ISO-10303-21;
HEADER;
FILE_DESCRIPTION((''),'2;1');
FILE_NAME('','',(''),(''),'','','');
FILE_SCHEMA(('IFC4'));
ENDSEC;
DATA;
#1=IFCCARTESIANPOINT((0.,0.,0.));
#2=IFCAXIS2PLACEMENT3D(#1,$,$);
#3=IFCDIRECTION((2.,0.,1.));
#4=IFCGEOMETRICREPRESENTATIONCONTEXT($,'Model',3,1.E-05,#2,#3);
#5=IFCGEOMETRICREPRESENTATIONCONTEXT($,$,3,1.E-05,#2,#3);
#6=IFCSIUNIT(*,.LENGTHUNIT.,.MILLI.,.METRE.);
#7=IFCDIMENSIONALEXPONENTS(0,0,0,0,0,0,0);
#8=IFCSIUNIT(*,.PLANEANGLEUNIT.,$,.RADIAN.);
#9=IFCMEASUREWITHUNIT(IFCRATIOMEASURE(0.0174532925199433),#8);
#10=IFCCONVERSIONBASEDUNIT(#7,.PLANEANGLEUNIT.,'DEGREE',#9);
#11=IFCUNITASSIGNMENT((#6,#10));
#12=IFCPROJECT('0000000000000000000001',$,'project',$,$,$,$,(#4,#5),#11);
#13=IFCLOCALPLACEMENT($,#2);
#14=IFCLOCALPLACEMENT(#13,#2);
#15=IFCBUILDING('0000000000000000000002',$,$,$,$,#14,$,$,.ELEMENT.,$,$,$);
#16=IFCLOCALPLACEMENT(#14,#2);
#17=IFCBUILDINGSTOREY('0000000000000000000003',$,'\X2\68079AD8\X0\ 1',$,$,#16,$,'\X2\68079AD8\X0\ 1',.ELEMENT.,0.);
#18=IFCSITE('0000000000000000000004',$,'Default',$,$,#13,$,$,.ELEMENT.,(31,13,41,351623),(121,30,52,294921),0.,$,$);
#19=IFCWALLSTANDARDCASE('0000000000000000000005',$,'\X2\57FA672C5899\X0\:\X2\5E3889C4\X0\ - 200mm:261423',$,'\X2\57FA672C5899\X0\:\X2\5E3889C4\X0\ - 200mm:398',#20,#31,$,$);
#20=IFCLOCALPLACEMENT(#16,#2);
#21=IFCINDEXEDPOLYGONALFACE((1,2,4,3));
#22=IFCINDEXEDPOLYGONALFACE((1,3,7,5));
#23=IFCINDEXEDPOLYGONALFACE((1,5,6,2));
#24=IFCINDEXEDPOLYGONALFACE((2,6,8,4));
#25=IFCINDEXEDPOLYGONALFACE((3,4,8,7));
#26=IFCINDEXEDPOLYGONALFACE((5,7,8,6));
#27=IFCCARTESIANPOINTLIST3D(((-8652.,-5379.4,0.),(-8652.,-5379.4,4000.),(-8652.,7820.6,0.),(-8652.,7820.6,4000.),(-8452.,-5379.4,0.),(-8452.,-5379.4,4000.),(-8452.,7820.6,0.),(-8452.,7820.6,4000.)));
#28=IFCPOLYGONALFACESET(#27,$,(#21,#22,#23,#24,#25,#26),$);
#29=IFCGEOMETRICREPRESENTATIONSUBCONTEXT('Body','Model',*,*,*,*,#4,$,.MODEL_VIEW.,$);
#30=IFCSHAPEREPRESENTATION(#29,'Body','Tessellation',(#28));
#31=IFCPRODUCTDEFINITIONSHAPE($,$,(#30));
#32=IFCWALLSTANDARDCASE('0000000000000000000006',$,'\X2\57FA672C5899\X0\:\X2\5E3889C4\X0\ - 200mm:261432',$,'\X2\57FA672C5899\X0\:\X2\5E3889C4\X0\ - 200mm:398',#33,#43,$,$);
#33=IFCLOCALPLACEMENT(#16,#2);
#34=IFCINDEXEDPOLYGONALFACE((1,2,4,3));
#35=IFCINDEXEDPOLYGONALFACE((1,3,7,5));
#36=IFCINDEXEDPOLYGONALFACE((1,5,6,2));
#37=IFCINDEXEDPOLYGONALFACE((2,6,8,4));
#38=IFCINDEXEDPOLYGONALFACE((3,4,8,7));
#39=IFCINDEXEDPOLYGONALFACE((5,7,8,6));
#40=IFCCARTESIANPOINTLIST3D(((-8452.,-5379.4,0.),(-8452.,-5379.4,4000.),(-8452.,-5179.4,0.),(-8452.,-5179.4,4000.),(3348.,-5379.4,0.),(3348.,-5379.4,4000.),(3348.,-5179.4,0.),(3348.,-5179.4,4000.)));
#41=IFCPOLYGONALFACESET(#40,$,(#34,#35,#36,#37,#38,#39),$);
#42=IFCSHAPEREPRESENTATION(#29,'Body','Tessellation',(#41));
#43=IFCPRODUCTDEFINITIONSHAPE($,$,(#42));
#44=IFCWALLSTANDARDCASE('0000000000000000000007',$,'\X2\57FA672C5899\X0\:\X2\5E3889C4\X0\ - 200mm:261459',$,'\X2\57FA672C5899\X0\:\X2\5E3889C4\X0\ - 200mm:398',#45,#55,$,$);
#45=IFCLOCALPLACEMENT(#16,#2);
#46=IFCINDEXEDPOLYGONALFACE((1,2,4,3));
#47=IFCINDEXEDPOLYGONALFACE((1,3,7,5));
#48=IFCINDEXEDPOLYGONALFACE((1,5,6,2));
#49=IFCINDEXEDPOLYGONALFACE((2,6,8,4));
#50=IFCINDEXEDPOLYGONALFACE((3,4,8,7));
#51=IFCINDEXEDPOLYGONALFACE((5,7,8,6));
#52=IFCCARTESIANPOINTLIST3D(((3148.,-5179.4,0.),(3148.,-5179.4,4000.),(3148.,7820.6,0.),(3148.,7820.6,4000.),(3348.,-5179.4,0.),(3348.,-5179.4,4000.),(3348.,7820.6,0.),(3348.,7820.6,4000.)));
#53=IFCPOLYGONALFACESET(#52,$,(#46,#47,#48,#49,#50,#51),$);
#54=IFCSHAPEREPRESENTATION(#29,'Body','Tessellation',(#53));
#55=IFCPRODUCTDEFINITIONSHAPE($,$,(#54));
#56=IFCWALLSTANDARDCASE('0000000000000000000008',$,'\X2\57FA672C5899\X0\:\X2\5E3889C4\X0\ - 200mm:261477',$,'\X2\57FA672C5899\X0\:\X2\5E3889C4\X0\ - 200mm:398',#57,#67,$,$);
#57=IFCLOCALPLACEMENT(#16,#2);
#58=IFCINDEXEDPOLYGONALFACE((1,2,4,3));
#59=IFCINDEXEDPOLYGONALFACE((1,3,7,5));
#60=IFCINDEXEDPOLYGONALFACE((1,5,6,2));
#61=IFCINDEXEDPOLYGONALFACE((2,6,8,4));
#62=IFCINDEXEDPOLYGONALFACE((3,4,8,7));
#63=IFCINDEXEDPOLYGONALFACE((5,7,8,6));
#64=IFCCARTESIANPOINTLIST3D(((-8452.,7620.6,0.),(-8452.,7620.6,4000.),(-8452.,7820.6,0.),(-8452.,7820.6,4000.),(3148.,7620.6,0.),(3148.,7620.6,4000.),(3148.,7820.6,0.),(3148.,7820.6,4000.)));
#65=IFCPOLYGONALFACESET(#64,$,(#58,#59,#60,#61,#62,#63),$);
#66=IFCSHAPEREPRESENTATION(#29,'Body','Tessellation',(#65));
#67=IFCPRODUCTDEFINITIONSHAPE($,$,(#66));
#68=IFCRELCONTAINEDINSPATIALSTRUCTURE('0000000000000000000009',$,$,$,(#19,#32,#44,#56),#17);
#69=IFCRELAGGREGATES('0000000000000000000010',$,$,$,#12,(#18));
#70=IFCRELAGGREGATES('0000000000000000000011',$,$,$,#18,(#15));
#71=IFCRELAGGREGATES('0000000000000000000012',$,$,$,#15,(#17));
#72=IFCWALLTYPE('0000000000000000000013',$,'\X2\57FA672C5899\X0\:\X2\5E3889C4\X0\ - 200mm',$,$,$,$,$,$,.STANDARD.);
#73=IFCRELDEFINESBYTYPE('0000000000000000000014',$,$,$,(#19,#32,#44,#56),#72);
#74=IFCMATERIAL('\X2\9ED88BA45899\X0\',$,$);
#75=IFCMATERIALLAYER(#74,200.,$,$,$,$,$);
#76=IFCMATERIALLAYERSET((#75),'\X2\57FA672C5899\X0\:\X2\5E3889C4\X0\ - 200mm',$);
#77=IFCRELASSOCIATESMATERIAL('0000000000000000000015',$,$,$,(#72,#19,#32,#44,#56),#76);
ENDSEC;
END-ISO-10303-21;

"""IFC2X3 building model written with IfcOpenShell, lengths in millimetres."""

from ifc_helpers import new_model, entity, si_unit, converted_unit, direction, frame, frame_2d, origin, place, context, subcontext, project, spatial, rectangle, extrude, clip, halfspace, material, layer, layer_set, layer_usage, type_object, element, save


model = new_model("IFC2X3")

# Units and contexts
model_context = context("Model", 3, precision=1e-05, world=origin(), true_north=direction((2.0, 0.0, 1.0)))
context_of_model = context(None, 3, precision=1e-05, world=origin(), true_north=direction((2.0, 0.0, 1.0)))
body_context = subcontext(model_context, "Body", "Model", "MODEL_VIEW")
ifc_project = project(units=[si_unit("LENGTHUNIT", "METRE", prefix="MILLI"), converted_unit("PLANEANGLEUNIT", "DEGREE", entity("IfcRatioMeasure", 0.0174532925199433), si_unit("PLANEANGLEUNIT", "RADIAN"), dimensions=[0, 0, 0, 0, 0, 0, 0])], contexts=[model_context, context_of_model])

# Site, building, storey
site_placement = place(None, frame((0.0, 0.0, 0.0)))
site = spatial("IfcSite", under=ifc_project, at=site_placement, Name="Default", CompositionType="ELEMENT", RefLatitude=(31, 13, 41, 351623), RefLongitude=(121, 30, 52, 294921), RefElevation=0.0)
building_placement = place(site_placement, origin())
building = spatial("IfcBuilding", under=site, at=building_placement, CompositionType="ELEMENT")
storey_placement = place(building_placement, origin())
storey = spatial("IfcBuildingStorey", under=building, at=storey_placement, Name="标高 1", LongName="标高 1", CompositionType="ELEMENT", Elevation=0.0)

# Walls
ifc_material = material(Name="默认墙")
ifc_layer = layer(ifc_material, 200.0)
ifc_layer_set = layer_set([ifc_layer], Name="基本墙:常规 - 200mm")
ifc_layer_usage_1 = layer_usage(ifc_layer_set, "AXIS2", "NEGATIVE", 100.0)
wall_type = type_object("IfcWallType", Name="基本墙:常规 - 200mm", PredefinedType="STANDARD", material=ifc_layer_set)
wall_1_placement = place(storey_placement, frame((-8552.0, 7820.6, 0.0), z_axis=(0.0, 0.0, 1.0), x_axis=(0.0, -1.0, 0.0)))
element("IfcWallStandardCase", 1, at=wall_1_placement, inside=storey, type_object=wall_type, material=ifc_layer_usage_1, Name="基本墙:常规 - 200mm:261423", ObjectType="基本墙:常规 - 200mm:398", context=body_context, shape_type="Clipping", body=[
    clip(extrude(rectangle(XDim=13200.0, YDim=200.0, at=frame_2d((6600.0, 0.0), x_axis=(-1.0, 0.0))), origin(), (0.0, 0.0, 1.0), 4000.0), halfspace(origin(), True)),
])
ifc_layer_usage_2 = layer_usage(ifc_layer_set, "AXIS2", "NEGATIVE", 100.0)
wall_2_placement = place(storey_placement, frame((-8452.0, -5279.4, 0.0)))
element("IfcWallStandardCase", 2, at=wall_2_placement, inside=storey, type_object=wall_type, material=ifc_layer_usage_2, Name="基本墙:常规 - 200mm:261432", ObjectType="基本墙:常规 - 200mm:398", context=body_context, shape_type="Clipping", body=[
    clip(extrude(rectangle(XDim=11800.0, YDim=200.0, at=frame_2d((5900.0, 0.0), x_axis=(-1.0, 0.0))), origin(), (0.0, 0.0, 1.0), 4000.0), halfspace(origin(), True)),
])
ifc_layer_usage_3 = layer_usage(ifc_layer_set, "AXIS2", "NEGATIVE", 100.0)
wall_3_placement = place(storey_placement, frame((3248.0, -5179.4, 0.0), z_axis=(0.0, 0.0, 1.0), x_axis=(0.0, 1.0, 0.0)))
element("IfcWallStandardCase", 3, at=wall_3_placement, inside=storey, type_object=wall_type, material=ifc_layer_usage_3, Name="基本墙:常规 - 200mm:261459", ObjectType="基本墙:常规 - 200mm:398", context=body_context, shape_type="Clipping", body=[
    clip(extrude(rectangle(XDim=13000.0, YDim=200.0, at=frame_2d((6500.0, 0.0), x_axis=(-1.0, 0.0))), origin(), (0.0, 0.0, 1.0), 4000.0), halfspace(origin(), True)),
])
ifc_layer_usage_4 = layer_usage(ifc_layer_set, "AXIS2", "NEGATIVE", 100.0)
wall_4_placement = place(storey_placement, frame((3148.0, 7720.6, 0.0), z_axis=(0.0, 0.0, 1.0), x_axis=(-1.0, 0.0, 0.0)))
element("IfcWallStandardCase", 4, at=wall_4_placement, inside=storey, type_object=wall_type, material=ifc_layer_usage_4, Name="基本墙:常规 - 200mm:261477", ObjectType="基本墙:常规 - 200mm:398", context=body_context, shape_type="Clipping", body=[
    clip(extrude(rectangle(XDim=11600.0, YDim=200.0, at=frame_2d((5800.0, 0.0), x_axis=(-1.0, 0.0))), origin(), (0.0, 0.0, 1.0), 4000.0), halfspace(origin(), True)),
])

save(model, "model.ifc")
